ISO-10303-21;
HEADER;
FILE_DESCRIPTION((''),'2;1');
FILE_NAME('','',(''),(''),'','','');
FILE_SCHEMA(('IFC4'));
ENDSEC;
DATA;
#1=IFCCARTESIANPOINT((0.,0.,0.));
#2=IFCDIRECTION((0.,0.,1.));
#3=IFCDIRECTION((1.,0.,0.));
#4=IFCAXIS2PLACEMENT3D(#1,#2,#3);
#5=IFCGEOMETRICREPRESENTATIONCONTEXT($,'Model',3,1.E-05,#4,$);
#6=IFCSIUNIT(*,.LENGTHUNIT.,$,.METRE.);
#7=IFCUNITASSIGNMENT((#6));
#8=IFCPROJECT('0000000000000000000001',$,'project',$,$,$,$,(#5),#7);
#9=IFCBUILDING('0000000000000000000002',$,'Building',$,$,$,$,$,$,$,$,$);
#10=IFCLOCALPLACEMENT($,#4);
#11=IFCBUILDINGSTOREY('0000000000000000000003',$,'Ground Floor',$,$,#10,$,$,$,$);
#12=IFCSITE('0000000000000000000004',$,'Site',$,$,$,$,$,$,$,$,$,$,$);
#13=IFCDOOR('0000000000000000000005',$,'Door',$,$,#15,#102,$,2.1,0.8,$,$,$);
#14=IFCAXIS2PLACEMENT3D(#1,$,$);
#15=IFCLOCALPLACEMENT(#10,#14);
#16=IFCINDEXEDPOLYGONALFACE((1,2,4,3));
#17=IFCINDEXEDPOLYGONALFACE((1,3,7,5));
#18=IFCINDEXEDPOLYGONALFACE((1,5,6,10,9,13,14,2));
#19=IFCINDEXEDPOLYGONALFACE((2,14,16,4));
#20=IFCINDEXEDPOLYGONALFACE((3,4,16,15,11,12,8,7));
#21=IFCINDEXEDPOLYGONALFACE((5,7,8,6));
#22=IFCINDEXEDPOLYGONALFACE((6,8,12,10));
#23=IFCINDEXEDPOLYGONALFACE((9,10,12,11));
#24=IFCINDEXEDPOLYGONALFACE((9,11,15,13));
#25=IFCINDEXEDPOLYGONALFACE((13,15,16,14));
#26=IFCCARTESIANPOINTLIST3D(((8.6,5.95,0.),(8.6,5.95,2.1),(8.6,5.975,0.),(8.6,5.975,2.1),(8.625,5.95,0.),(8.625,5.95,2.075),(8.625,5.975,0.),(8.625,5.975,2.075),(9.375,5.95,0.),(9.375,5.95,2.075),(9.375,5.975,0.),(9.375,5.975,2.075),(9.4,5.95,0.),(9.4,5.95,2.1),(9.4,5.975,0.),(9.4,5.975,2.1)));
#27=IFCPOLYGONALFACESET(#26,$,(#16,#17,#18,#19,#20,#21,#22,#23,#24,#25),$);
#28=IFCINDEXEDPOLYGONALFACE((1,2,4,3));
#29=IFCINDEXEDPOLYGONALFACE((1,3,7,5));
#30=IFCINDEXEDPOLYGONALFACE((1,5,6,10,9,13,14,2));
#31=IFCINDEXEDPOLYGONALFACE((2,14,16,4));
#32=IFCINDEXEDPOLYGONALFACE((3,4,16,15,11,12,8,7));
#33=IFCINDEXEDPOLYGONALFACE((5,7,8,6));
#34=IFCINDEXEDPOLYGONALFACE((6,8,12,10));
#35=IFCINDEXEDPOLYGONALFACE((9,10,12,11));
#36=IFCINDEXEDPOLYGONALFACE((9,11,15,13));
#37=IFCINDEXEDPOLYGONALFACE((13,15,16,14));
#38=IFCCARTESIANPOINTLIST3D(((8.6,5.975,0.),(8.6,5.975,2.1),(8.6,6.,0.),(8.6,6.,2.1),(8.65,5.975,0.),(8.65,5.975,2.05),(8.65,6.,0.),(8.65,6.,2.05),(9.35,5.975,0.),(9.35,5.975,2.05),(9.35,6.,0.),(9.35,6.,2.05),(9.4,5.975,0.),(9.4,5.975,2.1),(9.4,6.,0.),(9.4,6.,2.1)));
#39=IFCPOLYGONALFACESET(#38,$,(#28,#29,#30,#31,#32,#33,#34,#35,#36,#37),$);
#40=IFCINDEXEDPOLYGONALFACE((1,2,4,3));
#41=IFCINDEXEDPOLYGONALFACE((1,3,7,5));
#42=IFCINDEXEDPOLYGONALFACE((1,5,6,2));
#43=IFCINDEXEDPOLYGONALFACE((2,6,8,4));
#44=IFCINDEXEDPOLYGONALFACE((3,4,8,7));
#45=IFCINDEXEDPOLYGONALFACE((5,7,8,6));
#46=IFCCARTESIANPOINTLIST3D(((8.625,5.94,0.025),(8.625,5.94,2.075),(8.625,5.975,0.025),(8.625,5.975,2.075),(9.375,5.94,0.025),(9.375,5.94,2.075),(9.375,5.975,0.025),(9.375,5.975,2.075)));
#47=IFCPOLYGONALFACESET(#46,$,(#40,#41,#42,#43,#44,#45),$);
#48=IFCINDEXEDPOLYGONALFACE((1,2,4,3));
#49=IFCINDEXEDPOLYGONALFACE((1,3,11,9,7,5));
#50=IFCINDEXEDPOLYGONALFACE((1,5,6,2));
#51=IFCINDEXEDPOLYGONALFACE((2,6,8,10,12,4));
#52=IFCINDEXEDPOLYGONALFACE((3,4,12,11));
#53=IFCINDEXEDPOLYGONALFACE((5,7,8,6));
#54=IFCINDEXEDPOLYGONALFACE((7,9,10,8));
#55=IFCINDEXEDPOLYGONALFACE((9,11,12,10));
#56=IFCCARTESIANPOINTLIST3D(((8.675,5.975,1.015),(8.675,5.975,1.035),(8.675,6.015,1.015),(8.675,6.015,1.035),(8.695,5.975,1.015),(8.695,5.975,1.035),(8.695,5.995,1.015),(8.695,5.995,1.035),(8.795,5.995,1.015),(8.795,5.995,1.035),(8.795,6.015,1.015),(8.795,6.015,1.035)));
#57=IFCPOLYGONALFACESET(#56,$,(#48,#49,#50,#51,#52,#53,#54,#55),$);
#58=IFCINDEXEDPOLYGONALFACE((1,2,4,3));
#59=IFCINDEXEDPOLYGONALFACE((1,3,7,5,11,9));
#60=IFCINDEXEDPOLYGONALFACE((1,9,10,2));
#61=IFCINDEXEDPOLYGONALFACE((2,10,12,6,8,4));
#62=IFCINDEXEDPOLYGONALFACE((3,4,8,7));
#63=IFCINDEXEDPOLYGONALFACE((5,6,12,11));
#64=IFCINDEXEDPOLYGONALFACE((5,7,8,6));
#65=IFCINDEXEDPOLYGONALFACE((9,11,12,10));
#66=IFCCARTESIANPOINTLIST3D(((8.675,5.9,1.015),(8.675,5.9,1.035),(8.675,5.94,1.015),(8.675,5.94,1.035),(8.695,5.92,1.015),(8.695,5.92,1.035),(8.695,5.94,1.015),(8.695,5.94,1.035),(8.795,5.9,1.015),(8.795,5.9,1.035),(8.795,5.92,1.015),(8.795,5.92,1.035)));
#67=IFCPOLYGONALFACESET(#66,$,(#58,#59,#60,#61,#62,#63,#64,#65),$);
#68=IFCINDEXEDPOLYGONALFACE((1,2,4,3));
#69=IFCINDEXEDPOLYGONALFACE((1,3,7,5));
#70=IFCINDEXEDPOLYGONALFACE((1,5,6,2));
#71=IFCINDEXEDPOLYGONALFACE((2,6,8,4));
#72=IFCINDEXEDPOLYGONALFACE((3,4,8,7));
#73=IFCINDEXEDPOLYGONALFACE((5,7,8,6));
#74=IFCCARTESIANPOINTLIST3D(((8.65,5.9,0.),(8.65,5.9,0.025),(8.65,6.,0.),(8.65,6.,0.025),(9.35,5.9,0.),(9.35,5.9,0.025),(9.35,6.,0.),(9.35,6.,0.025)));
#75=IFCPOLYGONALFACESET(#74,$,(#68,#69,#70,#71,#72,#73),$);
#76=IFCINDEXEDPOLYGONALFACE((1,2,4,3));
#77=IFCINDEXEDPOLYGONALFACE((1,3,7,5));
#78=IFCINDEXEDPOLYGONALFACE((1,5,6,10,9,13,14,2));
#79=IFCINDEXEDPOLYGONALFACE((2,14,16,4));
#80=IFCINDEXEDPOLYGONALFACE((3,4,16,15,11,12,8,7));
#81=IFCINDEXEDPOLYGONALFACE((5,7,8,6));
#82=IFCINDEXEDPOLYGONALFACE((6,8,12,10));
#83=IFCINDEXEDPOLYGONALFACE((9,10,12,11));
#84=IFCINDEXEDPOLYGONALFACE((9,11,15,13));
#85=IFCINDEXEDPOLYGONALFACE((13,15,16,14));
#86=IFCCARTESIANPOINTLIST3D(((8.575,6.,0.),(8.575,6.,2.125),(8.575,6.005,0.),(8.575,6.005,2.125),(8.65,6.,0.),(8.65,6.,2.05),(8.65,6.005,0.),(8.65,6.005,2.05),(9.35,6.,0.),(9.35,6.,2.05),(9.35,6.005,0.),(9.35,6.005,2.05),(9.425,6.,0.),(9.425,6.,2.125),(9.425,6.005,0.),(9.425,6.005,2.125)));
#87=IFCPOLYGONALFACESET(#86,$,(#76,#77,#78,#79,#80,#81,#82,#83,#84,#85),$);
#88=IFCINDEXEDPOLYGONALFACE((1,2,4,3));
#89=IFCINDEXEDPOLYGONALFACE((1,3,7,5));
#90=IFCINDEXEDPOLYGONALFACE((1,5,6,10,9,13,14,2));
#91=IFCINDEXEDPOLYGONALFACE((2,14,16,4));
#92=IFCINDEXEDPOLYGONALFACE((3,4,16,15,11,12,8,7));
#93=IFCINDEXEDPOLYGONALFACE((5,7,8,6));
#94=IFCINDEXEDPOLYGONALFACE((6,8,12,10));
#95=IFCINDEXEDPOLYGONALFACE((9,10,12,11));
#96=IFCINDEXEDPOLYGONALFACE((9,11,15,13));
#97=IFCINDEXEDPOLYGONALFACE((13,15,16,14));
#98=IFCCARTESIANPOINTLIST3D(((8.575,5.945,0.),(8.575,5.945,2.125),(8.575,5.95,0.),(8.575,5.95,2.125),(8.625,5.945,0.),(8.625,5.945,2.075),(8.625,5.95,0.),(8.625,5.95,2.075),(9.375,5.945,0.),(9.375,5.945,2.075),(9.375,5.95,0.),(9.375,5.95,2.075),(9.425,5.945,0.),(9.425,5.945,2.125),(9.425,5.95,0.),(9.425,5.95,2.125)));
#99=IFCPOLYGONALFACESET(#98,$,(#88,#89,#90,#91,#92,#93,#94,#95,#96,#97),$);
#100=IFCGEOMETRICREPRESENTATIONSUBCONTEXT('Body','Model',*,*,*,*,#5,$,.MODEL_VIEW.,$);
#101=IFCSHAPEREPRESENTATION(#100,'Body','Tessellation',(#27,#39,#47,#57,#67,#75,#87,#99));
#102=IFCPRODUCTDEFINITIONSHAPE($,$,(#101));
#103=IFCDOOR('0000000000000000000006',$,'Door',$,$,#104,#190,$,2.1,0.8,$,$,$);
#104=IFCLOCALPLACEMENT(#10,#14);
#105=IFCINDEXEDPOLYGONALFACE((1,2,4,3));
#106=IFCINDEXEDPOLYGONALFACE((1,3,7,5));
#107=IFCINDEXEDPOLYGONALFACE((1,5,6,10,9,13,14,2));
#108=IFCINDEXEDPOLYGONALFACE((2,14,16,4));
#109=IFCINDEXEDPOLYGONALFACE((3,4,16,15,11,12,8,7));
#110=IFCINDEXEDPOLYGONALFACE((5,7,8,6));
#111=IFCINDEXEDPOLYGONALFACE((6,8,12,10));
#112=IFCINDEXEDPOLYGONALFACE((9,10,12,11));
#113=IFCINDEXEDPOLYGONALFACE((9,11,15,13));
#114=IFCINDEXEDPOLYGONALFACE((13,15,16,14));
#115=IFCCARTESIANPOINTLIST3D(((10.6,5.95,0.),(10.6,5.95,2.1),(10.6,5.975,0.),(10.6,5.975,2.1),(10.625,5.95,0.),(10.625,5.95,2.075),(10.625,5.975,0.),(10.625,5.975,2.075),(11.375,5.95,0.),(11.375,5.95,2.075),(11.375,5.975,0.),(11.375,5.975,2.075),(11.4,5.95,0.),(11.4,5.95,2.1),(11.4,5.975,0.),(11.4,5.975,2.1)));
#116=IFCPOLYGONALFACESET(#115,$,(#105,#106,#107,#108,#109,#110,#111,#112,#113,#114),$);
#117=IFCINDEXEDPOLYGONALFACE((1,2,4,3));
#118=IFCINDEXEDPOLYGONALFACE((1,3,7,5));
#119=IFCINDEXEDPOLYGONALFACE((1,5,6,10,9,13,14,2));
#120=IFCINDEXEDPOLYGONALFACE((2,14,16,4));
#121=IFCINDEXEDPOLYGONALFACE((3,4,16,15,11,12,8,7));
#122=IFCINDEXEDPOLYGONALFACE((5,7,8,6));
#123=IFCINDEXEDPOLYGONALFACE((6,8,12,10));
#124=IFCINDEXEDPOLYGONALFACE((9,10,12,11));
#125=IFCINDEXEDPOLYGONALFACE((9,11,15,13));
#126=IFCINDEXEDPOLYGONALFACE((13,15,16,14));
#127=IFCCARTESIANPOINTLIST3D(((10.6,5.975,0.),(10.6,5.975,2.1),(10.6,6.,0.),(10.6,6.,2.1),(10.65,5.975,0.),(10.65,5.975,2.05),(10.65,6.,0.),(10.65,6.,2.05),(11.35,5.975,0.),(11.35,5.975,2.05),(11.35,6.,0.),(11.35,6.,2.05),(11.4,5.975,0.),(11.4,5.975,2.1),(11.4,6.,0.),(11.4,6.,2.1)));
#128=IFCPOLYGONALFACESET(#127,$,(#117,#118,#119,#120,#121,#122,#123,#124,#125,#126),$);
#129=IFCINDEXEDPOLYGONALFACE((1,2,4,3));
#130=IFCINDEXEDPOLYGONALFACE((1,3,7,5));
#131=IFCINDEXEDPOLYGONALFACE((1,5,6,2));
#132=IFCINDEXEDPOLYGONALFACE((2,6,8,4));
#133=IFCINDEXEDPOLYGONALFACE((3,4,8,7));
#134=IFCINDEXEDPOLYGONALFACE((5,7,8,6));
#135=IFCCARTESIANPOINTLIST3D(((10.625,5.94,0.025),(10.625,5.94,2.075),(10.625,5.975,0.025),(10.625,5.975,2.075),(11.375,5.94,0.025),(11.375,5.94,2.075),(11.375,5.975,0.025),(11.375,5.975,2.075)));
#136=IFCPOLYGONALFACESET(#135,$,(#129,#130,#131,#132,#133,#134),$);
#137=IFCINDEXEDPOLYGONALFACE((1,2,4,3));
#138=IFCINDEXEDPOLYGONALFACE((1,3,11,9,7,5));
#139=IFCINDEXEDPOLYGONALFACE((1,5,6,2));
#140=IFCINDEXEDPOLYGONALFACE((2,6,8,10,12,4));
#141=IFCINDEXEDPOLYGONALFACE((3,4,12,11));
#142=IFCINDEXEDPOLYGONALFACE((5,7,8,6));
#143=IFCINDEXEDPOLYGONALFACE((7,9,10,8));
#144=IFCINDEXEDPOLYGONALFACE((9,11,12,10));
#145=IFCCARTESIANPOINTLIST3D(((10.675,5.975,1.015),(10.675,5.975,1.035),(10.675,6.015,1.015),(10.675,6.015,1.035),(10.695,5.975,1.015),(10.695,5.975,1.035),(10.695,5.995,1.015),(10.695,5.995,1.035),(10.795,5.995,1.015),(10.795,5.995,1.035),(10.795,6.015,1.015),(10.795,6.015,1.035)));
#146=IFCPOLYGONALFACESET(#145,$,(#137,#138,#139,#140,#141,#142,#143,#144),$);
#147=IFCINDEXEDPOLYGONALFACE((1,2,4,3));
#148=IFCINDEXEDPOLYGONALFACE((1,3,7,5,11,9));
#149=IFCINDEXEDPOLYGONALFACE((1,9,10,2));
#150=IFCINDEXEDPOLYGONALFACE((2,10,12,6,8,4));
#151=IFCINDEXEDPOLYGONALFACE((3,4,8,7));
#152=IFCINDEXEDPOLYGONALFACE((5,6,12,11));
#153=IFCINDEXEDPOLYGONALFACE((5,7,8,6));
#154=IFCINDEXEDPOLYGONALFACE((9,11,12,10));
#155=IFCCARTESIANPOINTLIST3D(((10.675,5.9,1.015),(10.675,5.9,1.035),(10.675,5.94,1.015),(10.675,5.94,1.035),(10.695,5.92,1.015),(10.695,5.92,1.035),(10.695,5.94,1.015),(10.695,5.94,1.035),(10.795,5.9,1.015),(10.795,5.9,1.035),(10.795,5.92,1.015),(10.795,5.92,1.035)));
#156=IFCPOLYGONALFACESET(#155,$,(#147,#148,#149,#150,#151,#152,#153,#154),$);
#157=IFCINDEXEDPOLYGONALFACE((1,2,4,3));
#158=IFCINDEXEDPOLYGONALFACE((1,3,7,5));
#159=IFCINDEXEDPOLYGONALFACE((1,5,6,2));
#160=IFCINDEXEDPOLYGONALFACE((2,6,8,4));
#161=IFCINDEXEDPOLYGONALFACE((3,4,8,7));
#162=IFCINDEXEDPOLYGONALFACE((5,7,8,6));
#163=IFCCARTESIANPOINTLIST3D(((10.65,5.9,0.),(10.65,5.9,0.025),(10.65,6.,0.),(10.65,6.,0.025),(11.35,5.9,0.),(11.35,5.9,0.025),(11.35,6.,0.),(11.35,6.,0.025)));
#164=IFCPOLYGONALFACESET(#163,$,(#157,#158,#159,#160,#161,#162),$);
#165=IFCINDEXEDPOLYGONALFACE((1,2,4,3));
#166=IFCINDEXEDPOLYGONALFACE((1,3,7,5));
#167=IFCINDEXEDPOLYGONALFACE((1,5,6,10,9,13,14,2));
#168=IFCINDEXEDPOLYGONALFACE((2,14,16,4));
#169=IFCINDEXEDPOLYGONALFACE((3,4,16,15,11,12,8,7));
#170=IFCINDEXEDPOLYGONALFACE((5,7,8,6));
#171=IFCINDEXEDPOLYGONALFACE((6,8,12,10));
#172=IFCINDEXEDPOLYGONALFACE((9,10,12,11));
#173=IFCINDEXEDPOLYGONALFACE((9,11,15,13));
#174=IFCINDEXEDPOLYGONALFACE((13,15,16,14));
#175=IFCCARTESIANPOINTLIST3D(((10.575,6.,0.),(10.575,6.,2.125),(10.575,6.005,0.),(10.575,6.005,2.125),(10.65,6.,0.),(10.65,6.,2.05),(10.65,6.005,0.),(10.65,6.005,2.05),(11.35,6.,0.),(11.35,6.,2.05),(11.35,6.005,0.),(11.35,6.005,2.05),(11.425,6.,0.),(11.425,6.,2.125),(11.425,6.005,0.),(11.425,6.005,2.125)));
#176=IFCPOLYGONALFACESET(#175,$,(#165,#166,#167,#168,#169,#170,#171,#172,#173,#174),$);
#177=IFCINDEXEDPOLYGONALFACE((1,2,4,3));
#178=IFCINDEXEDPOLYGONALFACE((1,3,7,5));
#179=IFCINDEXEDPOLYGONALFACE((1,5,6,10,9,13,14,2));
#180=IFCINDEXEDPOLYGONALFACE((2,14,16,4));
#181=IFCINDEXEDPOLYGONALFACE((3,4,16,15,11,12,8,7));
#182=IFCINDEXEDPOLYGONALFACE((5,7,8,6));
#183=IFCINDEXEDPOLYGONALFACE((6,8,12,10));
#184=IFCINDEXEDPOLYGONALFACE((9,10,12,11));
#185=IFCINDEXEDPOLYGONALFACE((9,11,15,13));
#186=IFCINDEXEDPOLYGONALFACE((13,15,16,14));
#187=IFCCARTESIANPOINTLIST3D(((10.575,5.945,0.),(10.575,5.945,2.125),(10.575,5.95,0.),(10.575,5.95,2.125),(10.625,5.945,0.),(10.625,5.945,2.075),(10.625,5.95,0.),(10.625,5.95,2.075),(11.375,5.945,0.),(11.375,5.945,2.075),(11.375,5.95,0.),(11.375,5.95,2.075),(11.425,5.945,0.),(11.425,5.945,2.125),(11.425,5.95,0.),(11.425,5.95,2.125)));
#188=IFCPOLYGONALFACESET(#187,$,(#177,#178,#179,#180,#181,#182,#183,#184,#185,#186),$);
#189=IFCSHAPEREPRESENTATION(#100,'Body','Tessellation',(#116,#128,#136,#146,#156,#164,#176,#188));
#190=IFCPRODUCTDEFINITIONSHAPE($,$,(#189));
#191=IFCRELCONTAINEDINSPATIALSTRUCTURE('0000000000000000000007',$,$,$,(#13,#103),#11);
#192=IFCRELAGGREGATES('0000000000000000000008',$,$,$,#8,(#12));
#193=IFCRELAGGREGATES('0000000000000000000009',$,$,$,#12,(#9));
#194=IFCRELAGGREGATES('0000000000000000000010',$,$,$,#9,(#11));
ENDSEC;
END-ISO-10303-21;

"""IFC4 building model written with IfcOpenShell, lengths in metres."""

from ifc_helpers import new_model, si_unit, frame, origin_with_axes, place, context, subcontext, project, spatial, line, indexed_curve, outline, extrude, element, save


model = new_model("IFC4")

# Units and contexts
model_context = context("Model", 3, precision=1e-05, world=origin_with_axes())
body_context = subcontext(model_context, "Body", "Model", "MODEL_VIEW")
ifc_project = project(units=[si_unit("LENGTHUNIT", "METRE")], contexts=[model_context])

# Site, building, storey
site = spatial("IfcSite", under=ifc_project, Name="Site")
building = spatial("IfcBuilding", under=site, Name="Building")
storey_placement = place(None, origin_with_axes())
storey = spatial("IfcBuildingStorey", under=building, at=storey_placement, Name="Ground Floor")

# Doors
door_1_placement = place(storey_placement, frame((9.4, 6.0, 0.0), z_axis=(0.0, 0.0, 1.0), x_axis=(-1.0, 0.0, 0.0)))
element("IfcDoor", 1, at=door_1_placement, inside=storey, Name="Door", OverallHeight=2.1, OverallWidth=0.8, context=body_context, shape_type="SweptSolid", body=[
    extrude(outline(indexed_curve([(0.0, 0.0), (0.0, 2.1), (0.8, 2.1), (0.8, 0.0), (0.775, 0.0), (0.775, 2.075), (0.025, 2.075), (0.025, 0.0)], segments=[line(1, 2, 3, 4, 5, 6, 7, 8, 1)])), frame((0.0, 0.025, 0.0), z_axis=(0.0, -1.0, 0.0), x_axis=(1.0, 0.0, 0.0)), (0.0, 0.0, -1.0), 0.025),
    extrude(outline(indexed_curve([(0.0, 0.0), (0.0, 2.1), (0.8, 2.1), (0.8, 0.0), (0.75, 0.0), (0.75, 2.05), (0.05, 2.05), (0.05, 0.0)], segments=[line(1, 2, 3, 4, 5, 6, 7, 8, 1)])), frame((0.0, 0.0, 0.0), z_axis=(0.0, -1.0, 0.0), x_axis=(1.0, 0.0, 0.0)), (0.0, 0.0, -1.0), 0.025),
    extrude(outline(indexed_curve([(0.0, 0.0), (0.75, 0.0), (0.75, 0.035), (0.0, 0.035)], segments=[line(1, 2, 3, 4, 1)])), frame((0.025, 0.025, 0.025), z_axis=(0.0, 0.0, 1.0), x_axis=(1.0, 0.0, 0.0)), (0.0, 0.0, 1.0), 2.05),
    extrude(outline(indexed_curve([(0.0, 0.0), (0.0, -0.04), (-0.12, -0.04), (-0.12, -0.02), (-0.02, -0.02), (-0.02, 0.0)], segments=[line(1, 2, 3, 4, 5, 6, 1)])), frame((0.725, 0.025, 1.015), z_axis=(0.0, 0.0, 1.0), x_axis=(1.0, 0.0, 0.0)), (0.0, 0.0, 1.0), 0.02),
    extrude(outline(indexed_curve([(0.0, 0.0), (0.0, 0.04), (-0.12, 0.04), (-0.12, 0.02), (-0.02, 0.02), (-0.02, 0.0)], segments=[line(1, 2, 3, 4, 5, 6, 1)])), frame((0.725, 0.06, 1.015), z_axis=(0.0, 0.0, 1.0), x_axis=(1.0, 0.0, 0.0)), (0.0, 0.0, 1.0), 0.02),
    extrude(outline(indexed_curve([(0.0, 0.0), (0.7, 0.0), (0.7, 0.1), (0.0, 0.1)], segments=[line(1, 2, 3, 4, 1)])), frame((0.05, 0.0, 0.0), z_axis=(0.0, 0.0, 1.0), x_axis=(1.0, 0.0, 0.0)), (0.0, 0.0, 1.0), 0.025),
    extrude(outline(indexed_curve([(0.0, 0.0), (0.0, 2.125), (0.85, 2.125), (0.85, 0.0), (0.775, 0.0), (0.775, 2.05), (0.075, 2.05), (0.075, 0.0)], segments=[line(1, 2, 3, 4, 5, 6, 7, 8, 1)])), frame((-0.025, -0.005, 0.0), z_axis=(0.0, -1.0, 0.0), x_axis=(1.0, 0.0, 0.0)), (0.0, 0.0, -1.0), 0.005),
    extrude(outline(indexed_curve([(0.0, 0.0), (0.0, 2.125), (0.85, 2.125), (0.85, 0.0), (0.8, 0.0), (0.8, 2.075), (0.05, 2.075), (0.05, 0.0)], segments=[line(1, 2, 3, 4, 5, 6, 7, 8, 1)])), frame((-0.025, 0.05, 0.0), z_axis=(0.0, -1.0, 0.0), x_axis=(1.0, 0.0, 0.0)), (0.0, 0.0, -1.0), 0.005),
])
door_2_placement = place(storey_placement, frame((11.4, 6.0, 0.0), z_axis=(0.0, 0.0, 1.0), x_axis=(-1.0, 0.0, 0.0)))
element("IfcDoor", 2, at=door_2_placement, inside=storey, Name="Door", OverallHeight=2.1, OverallWidth=0.8, context=body_context, shape_type="SweptSolid", body=[
    extrude(outline(indexed_curve([(0.0, 0.0), (0.0, 2.1), (0.8, 2.1), (0.8, 0.0), (0.775, 0.0), (0.775, 2.075), (0.025, 2.075), (0.025, 0.0)], segments=[line(1, 2, 3, 4, 5, 6, 7, 8, 1)])), frame((0.0, 0.025, 0.0), z_axis=(0.0, -1.0, 0.0), x_axis=(1.0, 0.0, 0.0)), (0.0, 0.0, -1.0), 0.025),
    extrude(outline(indexed_curve([(0.0, 0.0), (0.0, 2.1), (0.8, 2.1), (0.8, 0.0), (0.75, 0.0), (0.75, 2.05), (0.05, 2.05), (0.05, 0.0)], segments=[line(1, 2, 3, 4, 5, 6, 7, 8, 1)])), frame((0.0, 0.0, 0.0), z_axis=(0.0, -1.0, 0.0), x_axis=(1.0, 0.0, 0.0)), (0.0, 0.0, -1.0), 0.025),
    extrude(outline(indexed_curve([(0.0, 0.0), (0.75, 0.0), (0.75, 0.035), (0.0, 0.035)], segments=[line(1, 2, 3, 4, 1)])), frame((0.025, 0.025, 0.025), z_axis=(0.0, 0.0, 1.0), x_axis=(1.0, 0.0, 0.0)), (0.0, 0.0, 1.0), 2.05),
    extrude(outline(indexed_curve([(0.0, 0.0), (0.0, -0.04), (-0.12, -0.04), (-0.12, -0.02), (-0.02, -0.02), (-0.02, 0.0)], segments=[line(1, 2, 3, 4, 5, 6, 1)])), frame((0.725, 0.025, 1.015), z_axis=(0.0, 0.0, 1.0), x_axis=(1.0, 0.0, 0.0)), (0.0, 0.0, 1.0), 0.02),
    extrude(outline(indexed_curve([(0.0, 0.0), (0.0, 0.04), (-0.12, 0.04), (-0.12, 0.02), (-0.02, 0.02), (-0.02, 0.0)], segments=[line(1, 2, 3, 4, 5, 6, 1)])), frame((0.725, 0.06, 1.015), z_axis=(0.0, 0.0, 1.0), x_axis=(1.0, 0.0, 0.0)), (0.0, 0.0, 1.0), 0.02),
    extrude(outline(indexed_curve([(0.0, 0.0), (0.7, 0.0), (0.7, 0.1), (0.0, 0.1)], segments=[line(1, 2, 3, 4, 1)])), frame((0.05, 0.0, 0.0), z_axis=(0.0, 0.0, 1.0), x_axis=(1.0, 0.0, 0.0)), (0.0, 0.0, 1.0), 0.025),
    extrude(outline(indexed_curve([(0.0, 0.0), (0.0, 2.125), (0.85, 2.125), (0.85, 0.0), (0.775, 0.0), (0.775, 2.05), (0.075, 2.05), (0.075, 0.0)], segments=[line(1, 2, 3, 4, 5, 6, 7, 8, 1)])), frame((-0.025, -0.005, 0.0), z_axis=(0.0, -1.0, 0.0), x_axis=(1.0, 0.0, 0.0)), (0.0, 0.0, -1.0), 0.005),
    extrude(outline(indexed_curve([(0.0, 0.0), (0.0, 2.125), (0.85, 2.125), (0.85, 0.0), (0.8, 0.0), (0.8, 2.075), (0.05, 2.075), (0.05, 0.0)], segments=[line(1, 2, 3, 4, 5, 6, 7, 8, 1)])), frame((-0.025, 0.05, 0.0), z_axis=(0.0, -1.0, 0.0), x_axis=(1.0, 0.0, 0.0)), (0.0, 0.0, -1.0), 0.005),
])

save(model, "model.ifc")
